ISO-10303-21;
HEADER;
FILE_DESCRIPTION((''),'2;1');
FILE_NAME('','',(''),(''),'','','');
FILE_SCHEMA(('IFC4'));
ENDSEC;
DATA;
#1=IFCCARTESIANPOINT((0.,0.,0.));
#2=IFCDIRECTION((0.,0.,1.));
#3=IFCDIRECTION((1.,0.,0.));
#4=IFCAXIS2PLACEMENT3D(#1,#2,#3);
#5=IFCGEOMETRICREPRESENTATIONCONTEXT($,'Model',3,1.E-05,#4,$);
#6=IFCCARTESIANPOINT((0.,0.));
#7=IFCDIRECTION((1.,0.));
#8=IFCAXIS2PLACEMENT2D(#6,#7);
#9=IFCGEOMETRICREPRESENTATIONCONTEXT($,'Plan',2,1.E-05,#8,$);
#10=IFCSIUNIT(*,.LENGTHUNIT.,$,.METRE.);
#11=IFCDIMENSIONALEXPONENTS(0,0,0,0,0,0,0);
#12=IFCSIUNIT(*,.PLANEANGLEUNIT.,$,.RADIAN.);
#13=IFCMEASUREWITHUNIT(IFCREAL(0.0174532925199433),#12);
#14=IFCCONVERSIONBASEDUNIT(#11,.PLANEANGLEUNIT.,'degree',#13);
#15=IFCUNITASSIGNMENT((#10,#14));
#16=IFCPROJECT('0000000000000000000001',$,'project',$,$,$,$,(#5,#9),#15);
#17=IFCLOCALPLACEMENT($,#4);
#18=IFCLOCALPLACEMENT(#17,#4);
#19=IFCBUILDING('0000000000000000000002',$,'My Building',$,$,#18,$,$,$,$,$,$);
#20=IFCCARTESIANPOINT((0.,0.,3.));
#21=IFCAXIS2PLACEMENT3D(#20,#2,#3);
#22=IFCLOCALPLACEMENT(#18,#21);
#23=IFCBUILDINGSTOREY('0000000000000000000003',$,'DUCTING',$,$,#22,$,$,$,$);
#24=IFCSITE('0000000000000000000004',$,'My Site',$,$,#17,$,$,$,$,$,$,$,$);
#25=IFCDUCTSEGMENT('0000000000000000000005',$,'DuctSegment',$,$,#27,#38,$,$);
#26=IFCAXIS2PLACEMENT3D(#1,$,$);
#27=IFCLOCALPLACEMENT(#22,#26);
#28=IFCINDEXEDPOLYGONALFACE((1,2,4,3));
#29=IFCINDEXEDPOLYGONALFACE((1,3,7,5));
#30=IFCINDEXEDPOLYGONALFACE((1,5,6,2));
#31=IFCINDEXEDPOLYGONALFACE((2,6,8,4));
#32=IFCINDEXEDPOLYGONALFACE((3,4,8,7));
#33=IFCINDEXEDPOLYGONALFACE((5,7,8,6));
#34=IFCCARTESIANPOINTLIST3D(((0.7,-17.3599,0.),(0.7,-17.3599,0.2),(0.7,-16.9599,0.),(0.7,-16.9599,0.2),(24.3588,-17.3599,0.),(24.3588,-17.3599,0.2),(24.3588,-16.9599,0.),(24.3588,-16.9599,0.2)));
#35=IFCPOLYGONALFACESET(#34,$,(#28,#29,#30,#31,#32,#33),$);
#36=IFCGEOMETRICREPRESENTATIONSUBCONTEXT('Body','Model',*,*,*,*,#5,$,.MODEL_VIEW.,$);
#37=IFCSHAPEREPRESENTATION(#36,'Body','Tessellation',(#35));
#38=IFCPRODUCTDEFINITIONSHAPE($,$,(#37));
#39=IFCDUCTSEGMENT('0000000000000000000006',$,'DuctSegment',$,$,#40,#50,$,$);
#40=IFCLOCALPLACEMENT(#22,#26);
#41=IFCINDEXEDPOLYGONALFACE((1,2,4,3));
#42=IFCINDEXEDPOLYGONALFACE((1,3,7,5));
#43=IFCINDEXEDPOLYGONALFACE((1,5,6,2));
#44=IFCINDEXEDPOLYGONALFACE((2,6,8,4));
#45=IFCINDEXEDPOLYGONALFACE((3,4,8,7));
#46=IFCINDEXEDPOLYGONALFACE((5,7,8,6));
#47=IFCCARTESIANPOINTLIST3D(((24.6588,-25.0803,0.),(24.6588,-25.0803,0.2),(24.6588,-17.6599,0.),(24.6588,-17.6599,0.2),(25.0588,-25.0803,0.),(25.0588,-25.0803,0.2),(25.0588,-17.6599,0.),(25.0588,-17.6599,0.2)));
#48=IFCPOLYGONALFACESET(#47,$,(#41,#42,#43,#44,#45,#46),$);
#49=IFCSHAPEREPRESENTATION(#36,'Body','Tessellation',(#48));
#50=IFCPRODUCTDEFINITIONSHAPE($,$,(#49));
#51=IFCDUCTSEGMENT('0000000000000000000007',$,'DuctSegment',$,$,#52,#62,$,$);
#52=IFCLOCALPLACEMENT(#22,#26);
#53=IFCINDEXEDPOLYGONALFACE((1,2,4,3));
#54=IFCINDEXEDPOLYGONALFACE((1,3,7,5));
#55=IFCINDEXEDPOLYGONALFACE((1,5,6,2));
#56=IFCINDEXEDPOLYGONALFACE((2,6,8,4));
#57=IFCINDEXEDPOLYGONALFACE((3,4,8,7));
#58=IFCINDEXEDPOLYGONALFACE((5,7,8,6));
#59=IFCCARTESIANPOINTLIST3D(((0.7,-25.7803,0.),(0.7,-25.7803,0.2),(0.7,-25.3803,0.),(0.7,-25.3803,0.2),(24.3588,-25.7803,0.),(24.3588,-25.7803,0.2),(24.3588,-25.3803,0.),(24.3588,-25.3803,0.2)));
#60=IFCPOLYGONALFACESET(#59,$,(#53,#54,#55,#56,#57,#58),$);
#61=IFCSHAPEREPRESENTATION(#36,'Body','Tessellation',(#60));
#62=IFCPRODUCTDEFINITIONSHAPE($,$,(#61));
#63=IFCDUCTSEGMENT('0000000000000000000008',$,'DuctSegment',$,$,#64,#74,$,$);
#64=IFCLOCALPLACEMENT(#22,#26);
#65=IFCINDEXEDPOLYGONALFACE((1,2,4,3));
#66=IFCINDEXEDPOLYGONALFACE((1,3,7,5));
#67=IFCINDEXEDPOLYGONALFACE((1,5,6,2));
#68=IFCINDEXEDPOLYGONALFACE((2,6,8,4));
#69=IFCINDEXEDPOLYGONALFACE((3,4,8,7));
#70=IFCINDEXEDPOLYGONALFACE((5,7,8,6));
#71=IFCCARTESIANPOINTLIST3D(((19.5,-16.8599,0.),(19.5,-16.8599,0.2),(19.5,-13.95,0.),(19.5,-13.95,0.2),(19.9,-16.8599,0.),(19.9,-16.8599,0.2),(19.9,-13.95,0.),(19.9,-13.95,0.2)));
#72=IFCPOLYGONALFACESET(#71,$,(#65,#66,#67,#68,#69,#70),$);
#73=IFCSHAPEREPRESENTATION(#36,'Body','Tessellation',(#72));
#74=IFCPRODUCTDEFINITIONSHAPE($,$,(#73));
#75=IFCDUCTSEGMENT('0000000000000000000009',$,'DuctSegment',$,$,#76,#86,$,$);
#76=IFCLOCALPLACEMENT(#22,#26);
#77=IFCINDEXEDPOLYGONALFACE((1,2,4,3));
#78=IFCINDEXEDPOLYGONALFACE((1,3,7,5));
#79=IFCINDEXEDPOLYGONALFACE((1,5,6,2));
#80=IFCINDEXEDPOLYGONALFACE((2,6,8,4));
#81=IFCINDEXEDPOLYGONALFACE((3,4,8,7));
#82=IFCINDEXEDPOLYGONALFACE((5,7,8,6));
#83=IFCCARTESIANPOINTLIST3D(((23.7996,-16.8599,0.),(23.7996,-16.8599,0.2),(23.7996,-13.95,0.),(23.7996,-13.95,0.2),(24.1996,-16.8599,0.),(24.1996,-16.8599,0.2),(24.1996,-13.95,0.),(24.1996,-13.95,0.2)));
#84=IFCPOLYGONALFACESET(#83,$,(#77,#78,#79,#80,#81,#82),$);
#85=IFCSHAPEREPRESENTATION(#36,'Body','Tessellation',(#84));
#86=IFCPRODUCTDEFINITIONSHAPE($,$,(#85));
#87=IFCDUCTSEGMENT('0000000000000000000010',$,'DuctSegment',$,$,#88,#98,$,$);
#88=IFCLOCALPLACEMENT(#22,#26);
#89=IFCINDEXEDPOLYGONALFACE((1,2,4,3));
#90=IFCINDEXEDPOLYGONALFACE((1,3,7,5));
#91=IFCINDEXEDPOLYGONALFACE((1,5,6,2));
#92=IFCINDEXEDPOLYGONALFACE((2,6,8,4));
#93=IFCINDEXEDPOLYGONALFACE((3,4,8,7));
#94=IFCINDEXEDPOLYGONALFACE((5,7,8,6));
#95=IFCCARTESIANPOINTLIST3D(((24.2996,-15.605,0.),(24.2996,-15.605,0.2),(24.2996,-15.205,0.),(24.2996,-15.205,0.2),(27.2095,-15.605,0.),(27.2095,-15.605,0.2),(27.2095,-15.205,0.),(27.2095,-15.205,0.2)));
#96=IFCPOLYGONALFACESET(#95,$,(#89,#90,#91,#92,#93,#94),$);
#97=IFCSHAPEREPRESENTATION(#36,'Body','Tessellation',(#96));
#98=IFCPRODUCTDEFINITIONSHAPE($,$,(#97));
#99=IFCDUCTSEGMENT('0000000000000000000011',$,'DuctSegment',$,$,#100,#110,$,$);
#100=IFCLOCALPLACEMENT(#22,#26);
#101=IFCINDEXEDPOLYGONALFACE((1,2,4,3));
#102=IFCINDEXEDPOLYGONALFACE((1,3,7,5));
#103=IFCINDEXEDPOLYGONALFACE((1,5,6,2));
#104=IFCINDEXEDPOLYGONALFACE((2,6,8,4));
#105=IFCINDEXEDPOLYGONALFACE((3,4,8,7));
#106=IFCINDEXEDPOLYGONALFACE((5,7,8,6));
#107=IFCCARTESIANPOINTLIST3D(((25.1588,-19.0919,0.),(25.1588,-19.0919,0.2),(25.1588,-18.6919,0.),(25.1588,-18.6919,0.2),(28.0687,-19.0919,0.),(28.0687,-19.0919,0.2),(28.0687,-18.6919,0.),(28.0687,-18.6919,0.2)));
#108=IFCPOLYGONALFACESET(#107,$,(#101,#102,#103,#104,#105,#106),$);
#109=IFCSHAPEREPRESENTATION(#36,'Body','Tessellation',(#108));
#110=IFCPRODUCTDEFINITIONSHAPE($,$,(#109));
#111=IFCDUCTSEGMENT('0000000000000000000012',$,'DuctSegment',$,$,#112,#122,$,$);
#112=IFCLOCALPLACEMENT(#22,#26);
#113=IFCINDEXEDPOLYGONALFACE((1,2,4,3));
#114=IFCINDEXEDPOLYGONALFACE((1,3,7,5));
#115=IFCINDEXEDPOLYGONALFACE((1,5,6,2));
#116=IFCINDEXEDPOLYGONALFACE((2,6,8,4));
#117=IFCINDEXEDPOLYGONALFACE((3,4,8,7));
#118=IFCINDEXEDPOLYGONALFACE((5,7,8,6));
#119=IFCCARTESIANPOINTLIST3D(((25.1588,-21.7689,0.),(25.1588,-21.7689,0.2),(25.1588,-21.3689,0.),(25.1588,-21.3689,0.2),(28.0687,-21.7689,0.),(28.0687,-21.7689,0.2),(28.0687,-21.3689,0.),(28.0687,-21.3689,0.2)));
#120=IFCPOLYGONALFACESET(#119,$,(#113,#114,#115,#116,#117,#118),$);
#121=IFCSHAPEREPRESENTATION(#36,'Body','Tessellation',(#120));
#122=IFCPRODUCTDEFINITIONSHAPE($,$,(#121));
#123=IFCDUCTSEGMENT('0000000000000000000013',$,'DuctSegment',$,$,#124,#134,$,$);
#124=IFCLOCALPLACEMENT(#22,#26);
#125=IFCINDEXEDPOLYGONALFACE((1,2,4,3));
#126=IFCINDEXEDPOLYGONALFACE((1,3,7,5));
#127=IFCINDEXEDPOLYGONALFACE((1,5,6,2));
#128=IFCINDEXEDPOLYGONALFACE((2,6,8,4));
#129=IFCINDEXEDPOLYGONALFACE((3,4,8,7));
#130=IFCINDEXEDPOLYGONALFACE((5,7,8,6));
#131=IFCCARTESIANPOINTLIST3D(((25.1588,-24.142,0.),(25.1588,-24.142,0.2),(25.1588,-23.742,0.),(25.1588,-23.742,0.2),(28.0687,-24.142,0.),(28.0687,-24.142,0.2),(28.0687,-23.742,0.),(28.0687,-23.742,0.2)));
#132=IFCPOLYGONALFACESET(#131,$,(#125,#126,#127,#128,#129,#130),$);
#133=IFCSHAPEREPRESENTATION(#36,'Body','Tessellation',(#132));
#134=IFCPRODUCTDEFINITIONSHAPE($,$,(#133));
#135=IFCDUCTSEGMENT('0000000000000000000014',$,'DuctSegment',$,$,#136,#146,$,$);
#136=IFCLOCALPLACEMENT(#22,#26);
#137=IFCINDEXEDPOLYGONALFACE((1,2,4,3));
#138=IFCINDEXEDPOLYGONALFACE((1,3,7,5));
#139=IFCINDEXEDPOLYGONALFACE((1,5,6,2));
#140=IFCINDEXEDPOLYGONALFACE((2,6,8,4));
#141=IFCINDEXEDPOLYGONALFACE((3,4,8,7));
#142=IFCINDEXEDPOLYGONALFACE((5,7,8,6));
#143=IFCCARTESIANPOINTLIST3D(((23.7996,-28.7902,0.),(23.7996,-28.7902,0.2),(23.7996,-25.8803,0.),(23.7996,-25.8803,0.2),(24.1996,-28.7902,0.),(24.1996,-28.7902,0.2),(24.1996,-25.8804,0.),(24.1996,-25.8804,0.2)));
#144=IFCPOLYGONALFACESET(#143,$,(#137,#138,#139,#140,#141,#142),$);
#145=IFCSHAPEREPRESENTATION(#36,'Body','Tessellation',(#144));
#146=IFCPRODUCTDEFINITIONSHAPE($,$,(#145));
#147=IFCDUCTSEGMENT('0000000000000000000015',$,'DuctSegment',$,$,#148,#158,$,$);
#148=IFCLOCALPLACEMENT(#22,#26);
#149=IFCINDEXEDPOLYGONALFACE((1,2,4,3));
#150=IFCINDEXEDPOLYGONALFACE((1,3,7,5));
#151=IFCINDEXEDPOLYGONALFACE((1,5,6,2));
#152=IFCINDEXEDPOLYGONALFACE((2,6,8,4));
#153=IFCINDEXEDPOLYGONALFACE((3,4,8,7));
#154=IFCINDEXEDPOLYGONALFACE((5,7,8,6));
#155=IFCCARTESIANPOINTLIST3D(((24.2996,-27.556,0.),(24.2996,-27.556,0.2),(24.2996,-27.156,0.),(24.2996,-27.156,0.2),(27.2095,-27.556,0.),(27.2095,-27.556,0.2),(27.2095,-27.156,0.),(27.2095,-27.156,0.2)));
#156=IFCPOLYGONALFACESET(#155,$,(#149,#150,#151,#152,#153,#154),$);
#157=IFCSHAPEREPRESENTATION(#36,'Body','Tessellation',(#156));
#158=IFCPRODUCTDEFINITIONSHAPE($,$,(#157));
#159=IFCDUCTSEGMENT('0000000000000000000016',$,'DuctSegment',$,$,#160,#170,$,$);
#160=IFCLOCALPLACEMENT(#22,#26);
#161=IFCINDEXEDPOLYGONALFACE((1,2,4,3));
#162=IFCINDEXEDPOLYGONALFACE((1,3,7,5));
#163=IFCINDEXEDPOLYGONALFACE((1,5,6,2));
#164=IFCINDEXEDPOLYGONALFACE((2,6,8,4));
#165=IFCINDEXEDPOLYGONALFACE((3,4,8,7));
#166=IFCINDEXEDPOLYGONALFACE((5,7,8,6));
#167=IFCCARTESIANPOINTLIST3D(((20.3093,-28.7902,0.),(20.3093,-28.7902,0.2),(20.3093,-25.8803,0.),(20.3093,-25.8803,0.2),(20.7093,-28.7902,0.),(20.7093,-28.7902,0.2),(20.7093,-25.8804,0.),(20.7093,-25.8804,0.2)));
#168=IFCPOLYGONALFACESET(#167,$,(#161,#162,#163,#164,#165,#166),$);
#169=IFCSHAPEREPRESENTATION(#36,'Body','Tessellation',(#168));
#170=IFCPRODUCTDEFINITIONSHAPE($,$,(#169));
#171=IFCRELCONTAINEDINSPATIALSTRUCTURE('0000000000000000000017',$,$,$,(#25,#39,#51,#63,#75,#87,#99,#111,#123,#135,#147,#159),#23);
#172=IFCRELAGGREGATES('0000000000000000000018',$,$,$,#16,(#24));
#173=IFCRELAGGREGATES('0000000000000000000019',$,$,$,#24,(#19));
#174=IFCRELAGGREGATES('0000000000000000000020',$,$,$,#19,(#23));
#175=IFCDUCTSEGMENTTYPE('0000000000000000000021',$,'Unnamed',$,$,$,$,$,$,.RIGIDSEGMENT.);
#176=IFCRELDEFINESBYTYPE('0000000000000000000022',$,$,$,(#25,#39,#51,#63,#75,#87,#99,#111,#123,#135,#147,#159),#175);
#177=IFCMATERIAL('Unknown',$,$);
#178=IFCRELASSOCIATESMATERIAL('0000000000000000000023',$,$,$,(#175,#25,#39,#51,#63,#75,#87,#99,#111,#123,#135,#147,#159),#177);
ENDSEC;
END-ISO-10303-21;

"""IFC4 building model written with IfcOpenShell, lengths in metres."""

from ifc_helpers import new_model, entity, si_unit, converted_unit, frame, origin_with_axes, origin_2d_with_axis, place, context, subcontext, project, spatial, rectangle, extrude, material, material_profile, profile_set, profile_usage, type_object, element, save


model = new_model("IFC4")

# Units and contexts
model_context = context("Model", 3, precision=1e-05, world=origin_with_axes())
plan_context = context("Plan", 2, precision=1e-05, world=origin_2d_with_axis())
body_context = subcontext(model_context, "Body", "Model", "MODEL_VIEW")
ifc_project = project(units=[si_unit("LENGTHUNIT", "METRE"), converted_unit("PLANEANGLEUNIT", "degree", entity("IfcReal", 0.0174532925199433), si_unit("PLANEANGLEUNIT", "RADIAN"), dimensions=[0, 0, 0, 0, 0, 0, 0])], contexts=[model_context, plan_context])

# Site, building, storey
site_placement = place(None, origin_with_axes())
site = spatial("IfcSite", under=ifc_project, at=site_placement, Name="My Site")
building_placement = place(site_placement, origin_with_axes())
building = spatial("IfcBuilding", under=site, at=building_placement, Name="My Building")
storey_placement = place(building_placement, frame((0.0, 0.0, 3.0), z_axis=(0.0, 0.0, 1.0), x_axis=(1.0, 0.0, 0.0)))
storey = spatial("IfcBuildingStorey", under=building, at=storey_placement, Name="DUCTING")

# Duct segments
ifc_material = material(Name="Unknown")
ifc_material_profile_1 = material_profile(ifc_material, rectangle(XDim=0.4, YDim=0.2))
ifc_profile_set_1 = profile_set([ifc_material_profile_1])
ifc_profile_usage_1 = profile_usage(ifc_profile_set_1, cardinal=5)
duct_segment_type = type_object("IfcDuctSegmentType", Name="Unnamed", PredefinedType="RIGIDSEGMENT", material=ifc_profile_set_1)
duct_segment_1_placement = place(storey_placement, frame((24.3588, -17.1599, 0.1), z_axis=(-1.0, 0.0, 0.0), x_axis=(0.0, -1.0, 0.0)))
element("IfcDuctSegment", 1, at=duct_segment_1_placement, inside=storey, type_object=duct_segment_type, material=ifc_profile_usage_1, Name="DuctSegment", context=body_context, shape_type="SweptSolid", body=[
    extrude(rectangle(XDim=0.4, YDim=0.2), origin_with_axes(), (0.0, 0.0, 1.0), 23.6588),
])
ifc_profile_usage_2 = profile_usage(ifc_profile_set_1, cardinal=5)
duct_segment_2_placement = place(storey_placement, frame((24.8588, -17.6599, 0.1), z_axis=(0.0, -1.0, 0.0), x_axis=(1.0, 0.0, 0.0)))
element("IfcDuctSegment", 2, at=duct_segment_2_placement, inside=storey, type_object=duct_segment_type, material=ifc_profile_usage_2, Name="DuctSegment", context=body_context, shape_type="SweptSolid", body=[
    extrude(rectangle(XDim=0.4, YDim=0.2), origin_with_axes(), (0.0, 0.0, 1.0), 7.4205),
])
ifc_profile_usage_3 = profile_usage(ifc_profile_set_1, cardinal=5)
duct_segment_3_placement = place(storey_placement, frame((24.3588, -25.5803, 0.1), z_axis=(-1.0, 0.0, 0.0), x_axis=(0.0, -1.0, 0.0)))
element("IfcDuctSegment", 3, at=duct_segment_3_placement, inside=storey, type_object=duct_segment_type, material=ifc_profile_usage_3, Name="DuctSegment", context=body_context, shape_type="SweptSolid", body=[
    extrude(rectangle(XDim=0.4, YDim=0.2), origin_with_axes(), (0.0, 0.0, 1.0), 23.6588),
])
ifc_profile_usage_4 = profile_usage(ifc_profile_set_1, cardinal=5)
duct_segment_4_placement = place(storey_placement, frame((19.7, -13.95, 0.1), z_axis=(0.0, -1.0, 0.0), x_axis=(1.0, 0.0, 0.0)))
element("IfcDuctSegment", 4, at=duct_segment_4_placement, inside=storey, type_object=duct_segment_type, material=ifc_profile_usage_4, Name="DuctSegment", context=body_context, shape_type="SweptSolid", body=[
    extrude(rectangle(XDim=0.4, YDim=0.2), origin_with_axes(), (0.0, 0.0, 1.0), 2.9099),
])
ifc_profile_usage_5 = profile_usage(ifc_profile_set_1, cardinal=5)
duct_segment_5_placement = place(storey_placement, frame((23.9996, -13.95, 0.1), z_axis=(0.0, -1.0, 0.0), x_axis=(1.0, 0.0, 0.0)))
element("IfcDuctSegment", 5, at=duct_segment_5_placement, inside=storey, type_object=duct_segment_type, material=ifc_profile_usage_5, Name="DuctSegment", context=body_context, shape_type="SweptSolid", body=[
    extrude(rectangle(XDim=0.4, YDim=0.2), origin_with_axes(), (0.0, 0.0, 1.0), 2.9099),
])
ifc_profile_usage_6 = profile_usage(ifc_profile_set_1, cardinal=5)
duct_segment_6_placement = place(storey_placement, frame((27.2095, -15.405, 0.1), z_axis=(-1.0, 0.0, 0.0), x_axis=(0.0, -1.0, 0.0)))
element("IfcDuctSegment", 6, at=duct_segment_6_placement, inside=storey, type_object=duct_segment_type, material=ifc_profile_usage_6, Name="DuctSegment", context=body_context, shape_type="SweptSolid", body=[
    extrude(rectangle(XDim=0.4, YDim=0.2), origin_with_axes(), (0.0, 0.0, 1.0), 2.9099),
])
ifc_profile_usage_7 = profile_usage(ifc_profile_set_1, cardinal=5)
duct_segment_7_placement = place(storey_placement, frame((28.0687, -18.8919, 0.1), z_axis=(-1.0, 0.0, 0.0), x_axis=(0.0, -1.0, 0.0)))
element("IfcDuctSegment", 7, at=duct_segment_7_placement, inside=storey, type_object=duct_segment_type, material=ifc_profile_usage_7, Name="DuctSegment", context=body_context, shape_type="SweptSolid", body=[
    extrude(rectangle(XDim=0.4, YDim=0.2), origin_with_axes(), (0.0, 0.0, 1.0), 2.9099),
])
ifc_profile_usage_8 = profile_usage(ifc_profile_set_1, cardinal=5)
duct_segment_8_placement = place(storey_placement, frame((28.0687, -21.5689, 0.1), z_axis=(-1.0, 0.0, 0.0), x_axis=(0.0, -1.0, 0.0)))
element("IfcDuctSegment", 8, at=duct_segment_8_placement, inside=storey, type_object=duct_segment_type, material=ifc_profile_usage_8, Name="DuctSegment", context=body_context, shape_type="SweptSolid", body=[
    extrude(rectangle(XDim=0.4, YDim=0.2), origin_with_axes(), (0.0, 0.0, 1.0), 2.9099),
])
ifc_profile_usage_9 = profile_usage(ifc_profile_set_1, cardinal=5)
duct_segment_9_placement = place(storey_placement, frame((28.0687, -23.942, 0.1), z_axis=(-1.0, 0.0, 0.0), x_axis=(0.0, -1.0, 0.0)))
element("IfcDuctSegment", 9, at=duct_segment_9_placement, inside=storey, type_object=duct_segment_type, material=ifc_profile_usage_9, Name="DuctSegment", context=body_context, shape_type="SweptSolid", body=[
    extrude(rectangle(XDim=0.4, YDim=0.2), origin_with_axes(), (0.0, 0.0, 1.0), 2.9099),
])
ifc_profile_usage_10 = profile_usage(ifc_profile_set_1, cardinal=5)
duct_segment_10_placement = place(storey_placement, frame((23.9996, -28.7902, 0.1), z_axis=(0.000001, 1.0, 0.0), x_axis=(-1.0, 0.000001, 0.0)))
element("IfcDuctSegment", 10, at=duct_segment_10_placement, inside=storey, type_object=duct_segment_type, material=ifc_profile_usage_10, Name="DuctSegment", context=body_context, shape_type="SweptSolid", body=[
    extrude(rectangle(XDim=0.4, YDim=0.2), origin_with_axes(), (0.0, 0.0, 1.0), 2.9099),
])
ifc_profile_usage_11 = profile_usage(ifc_profile_set_1, cardinal=5)
duct_segment_11_placement = place(storey_placement, frame((27.2095, -27.356, 0.1), z_axis=(-1.0, 0.000001, 0.0), x_axis=(-0.000001, -1.0, 0.0)))
element("IfcDuctSegment", 11, at=duct_segment_11_placement, inside=storey, type_object=duct_segment_type, material=ifc_profile_usage_11, Name="DuctSegment", context=body_context, shape_type="SweptSolid", body=[
    extrude(rectangle(XDim=0.4, YDim=0.2), origin_with_axes(), (0.0, 0.0, 1.0), 2.9099),
])
ifc_profile_usage_12 = profile_usage(ifc_profile_set_1, cardinal=5)
duct_segment_12_placement = place(storey_placement, frame((20.5093, -28.7902, 0.1), z_axis=(0.000001, 1.0, 0.0), x_axis=(-1.0, 0.000001, 0.0)))
element("IfcDuctSegment", 12, at=duct_segment_12_placement, inside=storey, type_object=duct_segment_type, material=ifc_profile_usage_12, Name="DuctSegment", context=body_context, shape_type="SweptSolid", body=[
    extrude(rectangle(XDim=0.4, YDim=0.2), origin_with_axes(), (0.0, 0.0, 1.0), 2.9099),
])

save(model, "model.ifc")
